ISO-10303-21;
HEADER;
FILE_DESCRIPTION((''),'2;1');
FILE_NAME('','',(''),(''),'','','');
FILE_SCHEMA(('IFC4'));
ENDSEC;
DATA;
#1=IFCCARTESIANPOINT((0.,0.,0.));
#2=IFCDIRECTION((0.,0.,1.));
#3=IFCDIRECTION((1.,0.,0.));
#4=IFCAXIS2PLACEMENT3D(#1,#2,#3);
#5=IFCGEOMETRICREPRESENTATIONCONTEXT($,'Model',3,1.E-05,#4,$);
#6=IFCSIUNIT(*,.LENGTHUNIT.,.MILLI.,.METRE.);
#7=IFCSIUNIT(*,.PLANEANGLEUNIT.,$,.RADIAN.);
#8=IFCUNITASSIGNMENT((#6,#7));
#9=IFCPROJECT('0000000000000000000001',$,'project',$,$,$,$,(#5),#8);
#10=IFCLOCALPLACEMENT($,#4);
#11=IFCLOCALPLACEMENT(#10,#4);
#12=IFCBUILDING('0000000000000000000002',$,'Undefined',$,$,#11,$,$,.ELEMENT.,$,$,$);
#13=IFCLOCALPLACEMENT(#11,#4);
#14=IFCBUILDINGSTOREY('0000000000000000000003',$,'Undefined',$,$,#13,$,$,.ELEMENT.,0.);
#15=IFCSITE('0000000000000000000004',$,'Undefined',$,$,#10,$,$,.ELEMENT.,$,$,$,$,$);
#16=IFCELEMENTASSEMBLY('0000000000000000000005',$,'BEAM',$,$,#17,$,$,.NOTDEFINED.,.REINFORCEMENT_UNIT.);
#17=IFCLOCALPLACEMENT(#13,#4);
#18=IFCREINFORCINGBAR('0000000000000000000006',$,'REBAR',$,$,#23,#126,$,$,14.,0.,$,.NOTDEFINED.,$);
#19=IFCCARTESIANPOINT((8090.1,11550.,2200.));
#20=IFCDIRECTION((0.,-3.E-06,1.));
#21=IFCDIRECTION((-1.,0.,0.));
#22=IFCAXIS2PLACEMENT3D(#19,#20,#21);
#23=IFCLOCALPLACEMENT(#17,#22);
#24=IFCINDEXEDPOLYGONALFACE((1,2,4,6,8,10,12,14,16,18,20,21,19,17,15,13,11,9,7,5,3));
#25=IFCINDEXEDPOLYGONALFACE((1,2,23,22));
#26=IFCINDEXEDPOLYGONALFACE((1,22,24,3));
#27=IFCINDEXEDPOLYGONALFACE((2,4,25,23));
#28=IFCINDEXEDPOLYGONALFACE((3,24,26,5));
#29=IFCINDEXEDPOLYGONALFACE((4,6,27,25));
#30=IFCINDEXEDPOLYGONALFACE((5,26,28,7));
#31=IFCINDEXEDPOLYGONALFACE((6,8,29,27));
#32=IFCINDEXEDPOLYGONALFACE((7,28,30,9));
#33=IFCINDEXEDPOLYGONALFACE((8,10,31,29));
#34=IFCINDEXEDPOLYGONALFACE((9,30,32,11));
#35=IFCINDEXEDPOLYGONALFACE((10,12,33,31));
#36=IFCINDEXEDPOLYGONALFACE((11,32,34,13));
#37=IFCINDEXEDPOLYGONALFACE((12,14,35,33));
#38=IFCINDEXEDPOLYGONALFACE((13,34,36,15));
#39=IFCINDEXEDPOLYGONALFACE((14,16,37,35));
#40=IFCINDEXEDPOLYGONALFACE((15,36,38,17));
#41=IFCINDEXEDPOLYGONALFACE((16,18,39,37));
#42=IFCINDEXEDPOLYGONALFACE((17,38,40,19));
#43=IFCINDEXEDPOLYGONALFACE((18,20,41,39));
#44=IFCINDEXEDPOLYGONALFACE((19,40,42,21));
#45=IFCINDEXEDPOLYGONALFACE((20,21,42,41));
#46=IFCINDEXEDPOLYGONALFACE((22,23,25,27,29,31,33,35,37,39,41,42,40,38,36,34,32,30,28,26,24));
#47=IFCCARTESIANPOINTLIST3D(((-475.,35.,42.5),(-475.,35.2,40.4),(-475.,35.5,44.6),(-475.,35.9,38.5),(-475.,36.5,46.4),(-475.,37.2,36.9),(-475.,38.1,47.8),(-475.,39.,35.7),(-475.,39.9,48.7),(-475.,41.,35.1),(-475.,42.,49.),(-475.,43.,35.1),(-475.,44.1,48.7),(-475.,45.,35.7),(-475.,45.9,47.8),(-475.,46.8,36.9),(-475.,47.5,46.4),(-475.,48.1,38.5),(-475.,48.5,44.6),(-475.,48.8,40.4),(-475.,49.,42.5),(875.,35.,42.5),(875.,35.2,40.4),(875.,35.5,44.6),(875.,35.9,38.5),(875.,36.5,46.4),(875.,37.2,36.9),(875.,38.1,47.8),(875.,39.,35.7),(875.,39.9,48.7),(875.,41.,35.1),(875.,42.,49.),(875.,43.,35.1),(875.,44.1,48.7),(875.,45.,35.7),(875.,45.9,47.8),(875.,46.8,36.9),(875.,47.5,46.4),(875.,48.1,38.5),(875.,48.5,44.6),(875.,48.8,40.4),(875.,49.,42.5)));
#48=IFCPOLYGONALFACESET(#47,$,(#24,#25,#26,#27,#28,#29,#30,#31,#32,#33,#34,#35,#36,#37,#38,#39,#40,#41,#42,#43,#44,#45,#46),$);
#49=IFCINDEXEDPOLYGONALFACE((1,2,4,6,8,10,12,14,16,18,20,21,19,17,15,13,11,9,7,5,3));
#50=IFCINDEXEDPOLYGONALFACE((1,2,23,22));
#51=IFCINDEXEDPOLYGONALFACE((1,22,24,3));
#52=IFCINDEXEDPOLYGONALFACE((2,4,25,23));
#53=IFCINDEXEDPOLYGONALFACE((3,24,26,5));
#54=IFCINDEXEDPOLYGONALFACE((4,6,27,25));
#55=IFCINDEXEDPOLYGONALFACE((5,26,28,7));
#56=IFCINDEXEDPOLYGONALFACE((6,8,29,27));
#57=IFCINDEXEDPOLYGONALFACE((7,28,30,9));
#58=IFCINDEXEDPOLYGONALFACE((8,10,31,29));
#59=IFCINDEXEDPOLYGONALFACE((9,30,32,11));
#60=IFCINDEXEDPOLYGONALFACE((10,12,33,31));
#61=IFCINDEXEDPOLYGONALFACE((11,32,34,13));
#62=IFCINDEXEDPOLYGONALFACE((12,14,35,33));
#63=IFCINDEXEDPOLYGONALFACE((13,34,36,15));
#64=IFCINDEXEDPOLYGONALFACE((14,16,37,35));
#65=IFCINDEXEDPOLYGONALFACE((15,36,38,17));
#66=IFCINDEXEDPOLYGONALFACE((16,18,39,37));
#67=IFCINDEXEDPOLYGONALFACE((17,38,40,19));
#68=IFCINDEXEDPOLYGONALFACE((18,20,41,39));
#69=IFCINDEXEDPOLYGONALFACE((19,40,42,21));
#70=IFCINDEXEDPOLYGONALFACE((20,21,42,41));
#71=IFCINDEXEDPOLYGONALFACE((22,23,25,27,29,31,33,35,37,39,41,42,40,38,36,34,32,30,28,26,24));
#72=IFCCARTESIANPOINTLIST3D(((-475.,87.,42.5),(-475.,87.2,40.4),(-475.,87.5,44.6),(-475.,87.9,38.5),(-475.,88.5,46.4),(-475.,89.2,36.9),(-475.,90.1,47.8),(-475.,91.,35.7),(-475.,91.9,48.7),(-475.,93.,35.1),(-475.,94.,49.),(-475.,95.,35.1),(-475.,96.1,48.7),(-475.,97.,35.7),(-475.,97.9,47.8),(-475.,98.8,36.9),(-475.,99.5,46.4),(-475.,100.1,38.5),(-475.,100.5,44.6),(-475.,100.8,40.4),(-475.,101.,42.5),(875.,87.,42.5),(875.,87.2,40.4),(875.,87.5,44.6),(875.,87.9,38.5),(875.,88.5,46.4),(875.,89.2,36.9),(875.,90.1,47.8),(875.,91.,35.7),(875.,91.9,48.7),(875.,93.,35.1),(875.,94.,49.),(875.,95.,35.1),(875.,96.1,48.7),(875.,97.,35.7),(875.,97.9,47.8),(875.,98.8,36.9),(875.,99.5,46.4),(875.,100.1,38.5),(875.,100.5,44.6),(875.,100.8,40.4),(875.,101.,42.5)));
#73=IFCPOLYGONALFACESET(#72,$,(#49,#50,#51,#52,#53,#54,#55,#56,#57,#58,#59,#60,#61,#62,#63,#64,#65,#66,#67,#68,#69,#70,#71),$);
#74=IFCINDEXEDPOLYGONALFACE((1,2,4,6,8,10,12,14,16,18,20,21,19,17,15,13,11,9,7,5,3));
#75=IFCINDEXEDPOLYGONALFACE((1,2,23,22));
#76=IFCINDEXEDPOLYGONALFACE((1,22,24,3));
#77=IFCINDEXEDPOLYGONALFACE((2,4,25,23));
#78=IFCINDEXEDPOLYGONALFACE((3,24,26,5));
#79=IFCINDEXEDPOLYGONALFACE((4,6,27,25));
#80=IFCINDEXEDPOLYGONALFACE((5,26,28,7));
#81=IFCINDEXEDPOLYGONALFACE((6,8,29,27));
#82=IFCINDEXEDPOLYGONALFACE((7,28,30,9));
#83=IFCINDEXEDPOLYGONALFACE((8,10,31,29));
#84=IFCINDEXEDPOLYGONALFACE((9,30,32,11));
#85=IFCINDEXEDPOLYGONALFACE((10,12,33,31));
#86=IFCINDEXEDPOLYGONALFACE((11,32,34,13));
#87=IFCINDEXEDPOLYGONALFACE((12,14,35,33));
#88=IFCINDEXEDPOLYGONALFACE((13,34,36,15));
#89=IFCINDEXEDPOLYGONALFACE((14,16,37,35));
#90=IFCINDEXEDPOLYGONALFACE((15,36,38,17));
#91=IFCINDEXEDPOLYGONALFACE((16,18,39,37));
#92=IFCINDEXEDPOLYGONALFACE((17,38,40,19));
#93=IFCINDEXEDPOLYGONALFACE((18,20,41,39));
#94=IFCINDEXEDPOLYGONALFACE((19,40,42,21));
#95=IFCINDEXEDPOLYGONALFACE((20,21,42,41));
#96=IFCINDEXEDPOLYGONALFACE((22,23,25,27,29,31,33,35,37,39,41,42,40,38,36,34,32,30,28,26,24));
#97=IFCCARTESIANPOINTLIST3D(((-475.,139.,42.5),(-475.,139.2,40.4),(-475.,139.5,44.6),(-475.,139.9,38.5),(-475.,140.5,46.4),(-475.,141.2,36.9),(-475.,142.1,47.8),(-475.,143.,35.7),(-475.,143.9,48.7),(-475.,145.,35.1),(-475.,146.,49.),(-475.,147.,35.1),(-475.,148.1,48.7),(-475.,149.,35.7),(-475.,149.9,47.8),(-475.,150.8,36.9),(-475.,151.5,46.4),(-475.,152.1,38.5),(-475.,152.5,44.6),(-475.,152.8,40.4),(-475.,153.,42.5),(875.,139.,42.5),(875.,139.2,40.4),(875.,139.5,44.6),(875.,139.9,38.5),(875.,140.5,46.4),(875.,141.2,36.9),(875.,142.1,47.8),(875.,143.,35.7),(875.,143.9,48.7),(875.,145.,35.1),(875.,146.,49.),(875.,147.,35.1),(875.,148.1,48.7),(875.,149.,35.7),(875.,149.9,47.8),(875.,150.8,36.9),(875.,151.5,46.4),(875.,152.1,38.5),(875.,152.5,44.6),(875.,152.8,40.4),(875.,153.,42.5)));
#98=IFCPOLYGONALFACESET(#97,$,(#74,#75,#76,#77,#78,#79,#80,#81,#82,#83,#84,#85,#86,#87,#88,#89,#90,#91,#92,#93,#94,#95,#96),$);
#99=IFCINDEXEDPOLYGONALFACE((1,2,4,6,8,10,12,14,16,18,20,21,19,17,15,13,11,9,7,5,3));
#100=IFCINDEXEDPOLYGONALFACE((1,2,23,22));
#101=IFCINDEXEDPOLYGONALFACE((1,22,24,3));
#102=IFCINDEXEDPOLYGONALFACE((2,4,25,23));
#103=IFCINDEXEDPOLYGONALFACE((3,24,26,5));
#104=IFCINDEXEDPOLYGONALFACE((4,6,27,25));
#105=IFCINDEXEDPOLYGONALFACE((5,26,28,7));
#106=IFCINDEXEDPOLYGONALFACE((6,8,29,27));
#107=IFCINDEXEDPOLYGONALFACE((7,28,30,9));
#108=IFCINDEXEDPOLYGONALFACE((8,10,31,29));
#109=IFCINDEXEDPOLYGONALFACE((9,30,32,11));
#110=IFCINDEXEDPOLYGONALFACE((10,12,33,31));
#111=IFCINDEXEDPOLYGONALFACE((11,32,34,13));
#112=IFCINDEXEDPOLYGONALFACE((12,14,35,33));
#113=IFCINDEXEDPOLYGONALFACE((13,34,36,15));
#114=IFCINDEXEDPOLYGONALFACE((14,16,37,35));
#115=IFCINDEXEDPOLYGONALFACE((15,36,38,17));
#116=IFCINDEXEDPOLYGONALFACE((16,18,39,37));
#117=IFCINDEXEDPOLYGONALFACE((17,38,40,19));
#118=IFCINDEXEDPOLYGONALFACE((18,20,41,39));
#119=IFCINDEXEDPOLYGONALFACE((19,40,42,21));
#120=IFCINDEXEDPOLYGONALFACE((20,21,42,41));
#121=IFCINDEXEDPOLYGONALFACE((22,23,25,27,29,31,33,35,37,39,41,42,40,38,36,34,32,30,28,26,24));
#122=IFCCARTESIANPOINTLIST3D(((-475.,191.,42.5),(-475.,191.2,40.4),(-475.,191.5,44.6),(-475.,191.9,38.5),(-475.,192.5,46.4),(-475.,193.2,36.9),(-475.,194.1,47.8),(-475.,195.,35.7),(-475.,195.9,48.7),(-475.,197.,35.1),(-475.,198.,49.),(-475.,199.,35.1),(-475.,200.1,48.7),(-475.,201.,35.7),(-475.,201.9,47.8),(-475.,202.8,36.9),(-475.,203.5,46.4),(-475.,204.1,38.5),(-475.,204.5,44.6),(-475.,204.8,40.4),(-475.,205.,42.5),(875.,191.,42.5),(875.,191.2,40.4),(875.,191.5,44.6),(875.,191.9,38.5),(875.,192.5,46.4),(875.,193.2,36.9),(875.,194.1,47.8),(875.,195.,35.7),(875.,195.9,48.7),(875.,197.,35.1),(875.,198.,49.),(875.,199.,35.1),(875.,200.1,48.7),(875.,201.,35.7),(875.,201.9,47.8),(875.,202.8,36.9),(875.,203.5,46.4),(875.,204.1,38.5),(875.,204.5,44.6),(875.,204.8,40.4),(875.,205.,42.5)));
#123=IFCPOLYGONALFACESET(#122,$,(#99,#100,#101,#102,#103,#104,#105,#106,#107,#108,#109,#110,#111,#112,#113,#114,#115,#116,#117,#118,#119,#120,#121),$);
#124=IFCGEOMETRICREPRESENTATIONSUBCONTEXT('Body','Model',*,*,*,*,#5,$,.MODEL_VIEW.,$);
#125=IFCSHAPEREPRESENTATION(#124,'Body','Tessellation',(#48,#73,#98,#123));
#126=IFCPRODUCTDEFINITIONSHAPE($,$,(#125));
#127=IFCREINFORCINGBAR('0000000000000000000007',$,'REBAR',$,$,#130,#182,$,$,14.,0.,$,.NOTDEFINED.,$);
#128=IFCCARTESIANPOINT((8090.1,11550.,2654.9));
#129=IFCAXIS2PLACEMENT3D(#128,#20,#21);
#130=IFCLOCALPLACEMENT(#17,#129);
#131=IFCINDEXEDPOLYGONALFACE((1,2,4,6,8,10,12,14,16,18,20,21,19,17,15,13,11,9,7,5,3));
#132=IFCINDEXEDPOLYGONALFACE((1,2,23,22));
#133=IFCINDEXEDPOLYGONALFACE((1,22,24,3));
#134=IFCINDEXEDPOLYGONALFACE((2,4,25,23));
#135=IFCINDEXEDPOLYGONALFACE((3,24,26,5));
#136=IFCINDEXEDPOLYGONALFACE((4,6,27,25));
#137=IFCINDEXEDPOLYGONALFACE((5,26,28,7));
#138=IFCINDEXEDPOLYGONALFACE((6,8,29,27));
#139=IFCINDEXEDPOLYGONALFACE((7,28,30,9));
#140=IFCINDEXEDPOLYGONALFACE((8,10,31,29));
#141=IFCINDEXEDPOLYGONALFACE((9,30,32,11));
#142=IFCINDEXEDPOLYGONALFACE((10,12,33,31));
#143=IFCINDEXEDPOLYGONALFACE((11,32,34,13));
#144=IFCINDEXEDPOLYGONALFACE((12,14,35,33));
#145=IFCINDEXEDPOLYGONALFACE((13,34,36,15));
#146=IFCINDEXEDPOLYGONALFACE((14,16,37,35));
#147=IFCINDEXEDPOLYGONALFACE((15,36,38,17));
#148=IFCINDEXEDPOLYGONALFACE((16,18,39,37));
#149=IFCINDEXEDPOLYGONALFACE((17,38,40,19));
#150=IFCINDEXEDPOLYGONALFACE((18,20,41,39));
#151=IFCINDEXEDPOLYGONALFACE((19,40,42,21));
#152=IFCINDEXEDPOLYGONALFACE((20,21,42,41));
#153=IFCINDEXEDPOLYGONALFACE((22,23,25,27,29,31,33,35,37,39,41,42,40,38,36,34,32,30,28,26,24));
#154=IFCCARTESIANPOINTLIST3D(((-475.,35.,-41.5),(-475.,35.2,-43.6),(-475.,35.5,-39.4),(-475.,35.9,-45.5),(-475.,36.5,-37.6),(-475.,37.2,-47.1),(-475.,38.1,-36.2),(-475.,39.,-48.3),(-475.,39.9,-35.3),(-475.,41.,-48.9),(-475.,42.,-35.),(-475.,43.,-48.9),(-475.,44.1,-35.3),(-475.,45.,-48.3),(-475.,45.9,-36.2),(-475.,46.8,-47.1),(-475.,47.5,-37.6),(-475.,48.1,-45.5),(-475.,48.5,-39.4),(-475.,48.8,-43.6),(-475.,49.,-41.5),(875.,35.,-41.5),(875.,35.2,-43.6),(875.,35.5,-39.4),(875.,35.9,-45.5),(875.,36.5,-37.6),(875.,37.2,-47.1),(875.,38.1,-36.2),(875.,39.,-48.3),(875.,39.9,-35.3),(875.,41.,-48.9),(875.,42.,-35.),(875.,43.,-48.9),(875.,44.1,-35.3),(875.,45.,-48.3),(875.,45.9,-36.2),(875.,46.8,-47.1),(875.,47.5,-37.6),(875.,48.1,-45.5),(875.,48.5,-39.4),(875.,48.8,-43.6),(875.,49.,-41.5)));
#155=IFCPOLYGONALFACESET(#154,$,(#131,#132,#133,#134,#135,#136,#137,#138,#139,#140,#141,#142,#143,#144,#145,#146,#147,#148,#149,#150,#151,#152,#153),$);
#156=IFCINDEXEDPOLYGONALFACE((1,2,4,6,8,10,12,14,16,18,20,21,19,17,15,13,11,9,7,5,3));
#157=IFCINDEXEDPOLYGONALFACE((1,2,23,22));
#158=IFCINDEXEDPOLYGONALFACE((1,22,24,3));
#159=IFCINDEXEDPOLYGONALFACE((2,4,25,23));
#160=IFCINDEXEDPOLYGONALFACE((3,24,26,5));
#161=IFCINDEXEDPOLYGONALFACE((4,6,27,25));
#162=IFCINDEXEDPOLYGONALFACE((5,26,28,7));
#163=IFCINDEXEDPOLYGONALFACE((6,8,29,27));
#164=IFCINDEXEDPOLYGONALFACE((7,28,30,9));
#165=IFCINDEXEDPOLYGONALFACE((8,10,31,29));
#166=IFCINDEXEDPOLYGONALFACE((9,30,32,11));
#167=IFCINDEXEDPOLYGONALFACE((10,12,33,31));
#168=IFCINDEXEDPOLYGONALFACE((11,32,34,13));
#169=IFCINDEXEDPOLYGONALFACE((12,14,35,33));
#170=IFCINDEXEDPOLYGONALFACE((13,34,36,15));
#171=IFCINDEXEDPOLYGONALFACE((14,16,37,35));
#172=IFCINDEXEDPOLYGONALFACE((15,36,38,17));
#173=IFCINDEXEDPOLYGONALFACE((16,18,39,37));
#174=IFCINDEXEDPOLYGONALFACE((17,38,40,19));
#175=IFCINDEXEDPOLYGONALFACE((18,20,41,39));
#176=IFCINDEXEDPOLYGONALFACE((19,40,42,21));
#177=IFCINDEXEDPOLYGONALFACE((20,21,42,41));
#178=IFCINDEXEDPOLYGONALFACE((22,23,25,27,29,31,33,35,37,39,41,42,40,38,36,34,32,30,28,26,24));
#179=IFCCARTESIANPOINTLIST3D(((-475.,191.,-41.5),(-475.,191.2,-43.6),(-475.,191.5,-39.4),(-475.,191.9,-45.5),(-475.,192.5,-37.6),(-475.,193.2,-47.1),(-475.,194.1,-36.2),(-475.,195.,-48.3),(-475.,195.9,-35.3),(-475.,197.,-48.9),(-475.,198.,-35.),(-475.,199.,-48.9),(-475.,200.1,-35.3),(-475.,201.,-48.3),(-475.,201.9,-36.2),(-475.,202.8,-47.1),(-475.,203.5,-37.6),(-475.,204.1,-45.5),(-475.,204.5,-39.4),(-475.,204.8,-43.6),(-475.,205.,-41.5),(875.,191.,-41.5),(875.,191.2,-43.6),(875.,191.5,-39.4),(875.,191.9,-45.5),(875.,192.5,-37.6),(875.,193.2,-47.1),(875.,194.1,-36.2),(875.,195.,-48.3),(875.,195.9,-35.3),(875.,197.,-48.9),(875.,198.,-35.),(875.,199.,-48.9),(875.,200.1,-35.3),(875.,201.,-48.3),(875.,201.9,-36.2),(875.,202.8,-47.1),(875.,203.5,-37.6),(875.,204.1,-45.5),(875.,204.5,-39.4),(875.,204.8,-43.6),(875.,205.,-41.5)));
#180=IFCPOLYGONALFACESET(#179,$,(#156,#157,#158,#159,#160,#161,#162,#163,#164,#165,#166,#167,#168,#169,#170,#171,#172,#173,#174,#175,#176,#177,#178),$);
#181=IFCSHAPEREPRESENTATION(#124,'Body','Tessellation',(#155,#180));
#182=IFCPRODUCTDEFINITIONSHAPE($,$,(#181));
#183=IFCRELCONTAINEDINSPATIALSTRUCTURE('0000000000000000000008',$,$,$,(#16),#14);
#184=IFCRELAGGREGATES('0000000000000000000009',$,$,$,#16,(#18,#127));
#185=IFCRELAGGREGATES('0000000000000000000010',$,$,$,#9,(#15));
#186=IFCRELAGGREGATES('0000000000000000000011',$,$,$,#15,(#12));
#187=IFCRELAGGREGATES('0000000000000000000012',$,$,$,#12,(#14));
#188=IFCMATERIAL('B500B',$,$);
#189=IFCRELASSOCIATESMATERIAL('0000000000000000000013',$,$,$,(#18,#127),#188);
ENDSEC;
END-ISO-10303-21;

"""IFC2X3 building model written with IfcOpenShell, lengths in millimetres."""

from ifc_helpers import new_model, entity, si_unit, frame, origin_with_axes, place, context, subcontext, project, spatial, source, transform, mapped, material, element, aggregate, save


model = new_model("IFC2X3")

# Units and contexts
model_context = context("Model", 3, precision=1e-05, world=origin_with_axes())
body_context = subcontext(model_context, "Body", "Model", "MODEL_VIEW")
ifc_project = project(units=[si_unit("LENGTHUNIT", "METRE", prefix="MILLI"), si_unit("PLANEANGLEUNIT", "RADIAN")], contexts=[model_context])

# Site, building, storey
site_placement = place(None, origin_with_axes())
site = spatial("IfcSite", under=ifc_project, at=site_placement, Name="Undefined", CompositionType="ELEMENT")
building_placement = place(site_placement, origin_with_axes())
building = spatial("IfcBuilding", under=site, at=building_placement, Name="Undefined", CompositionType="ELEMENT")
storey_placement = place(building_placement, origin_with_axes())
storey = spatial("IfcBuildingStorey", under=building, at=storey_placement, Name="Undefined", CompositionType="ELEMENT", Elevation=0.0)

# Element assembly
assembly_1_placement = place(storey_placement, origin_with_axes())
assembly_1 = element("IfcElementAssembly", 1, at=assembly_1_placement, inside=storey, Name="BEAM", AssemblyPlace="NOTDEFINED", PredefinedType="REINFORCEMENT_UNIT")

# Shared definitions
ifc_material_1 = material(Name="B500B")

# Reinforcing bars
shared_shape_1 = source(origin_with_axes(), body_context, "Body", "AdvancedSweptSolid", [
    entity("IfcSweptDiskSolid", entity("IfcTrimmedCurve", entity("IfcLine", entity("IfcCartesianPoint", [0.0, 0.0, 0.0]), entity("IfcVector", entity("IfcDirection", [1.0, 0.0, 0.0]), 1.0)), [entity("IfcParameterValue", 0.0)], [entity("IfcParameterValue", 1349.999613)], True, "PARAMETER"), 7.0, None, 0.0, 1350.0),
])
shared_shape_2 = source(origin_with_axes(), body_context, "Body", "AdvancedSweptSolid", [
    entity("IfcSweptDiskSolid", entity("IfcTrimmedCurve", entity("IfcLine", entity("IfcCartesianPoint", [0.0, 0.0, 0.0]), entity("IfcVector", entity("IfcDirection", [1.0, 0.0, 0.0]), 1.0)), [entity("IfcParameterValue", 0.0)], [entity("IfcParameterValue", 1349.999613)], True, "PARAMETER"), 7.0, None, 0.0, 1350.0),
])
shared_shape_3 = source(origin_with_axes(), body_context, "Body", "AdvancedSweptSolid", [
    entity("IfcSweptDiskSolid", entity("IfcTrimmedCurve", entity("IfcLine", entity("IfcCartesianPoint", [0.0, 0.0, 0.0]), entity("IfcVector", entity("IfcDirection", [1.0, 0.0, 0.0]), 1.0)), [entity("IfcParameterValue", 0.0)], [entity("IfcParameterValue", 1349.999613)], True, "PARAMETER"), 7.0, None, 0.0, 1350.0),
])
shared_shape_4 = source(origin_with_axes(), body_context, "Body", "AdvancedSweptSolid", [
    entity("IfcSweptDiskSolid", entity("IfcTrimmedCurve", entity("IfcLine", entity("IfcCartesianPoint", [0.0, 0.0, 0.0]), entity("IfcVector", entity("IfcDirection", [1.0, 0.0, 0.0]), 1.0)), [entity("IfcParameterValue", 0.0)], [entity("IfcParameterValue", 1349.999613)], True, "PARAMETER"), 7.0, None, 0.0, 1350.0),
])
reinforcing_bar_1_placement = place(assembly_1_placement, frame((8090.1, 11550.0, 2200.0), z_axis=(0.0, -0.000003, 1.0), x_axis=(-1.0, 0.0, 0.0)))
reinforcing_bar_1 = element("IfcReinforcingBar", 2, at=reinforcing_bar_1_placement, material=ifc_material_1, Name="REBAR", BarRole="NOTDEFINED", CrossSectionArea=0.0, NominalDiameter=14.0, context=body_context, shape_type="MappedRepresentation", body=[
    mapped(shared_shape_1, transform((-475.0, 42.0, 42.0))),
    mapped(shared_shape_2, transform((-475.0, 94.0, 42.0))),
    mapped(shared_shape_3, transform((-475.0, 146.0, 42.0))),
    mapped(shared_shape_4, transform((-475.0, 198.0, 42.0))),
])
shared_shape_5 = source(origin_with_axes(), body_context, "Body", "AdvancedSweptSolid", [
    entity("IfcSweptDiskSolid", entity("IfcTrimmedCurve", entity("IfcLine", entity("IfcCartesianPoint", [0.0, 0.0, 0.0]), entity("IfcVector", entity("IfcDirection", [1.0, 0.0, 0.0]), 1.0)), [entity("IfcParameterValue", 0.0)], [entity("IfcParameterValue", 1349.999613)], True, "PARAMETER"), 7.0, None, 0.0, 1350.0),
])
shared_shape_6 = source(origin_with_axes(), body_context, "Body", "AdvancedSweptSolid", [
    entity("IfcSweptDiskSolid", entity("IfcTrimmedCurve", entity("IfcLine", entity("IfcCartesianPoint", [0.0, 0.0, 0.0]), entity("IfcVector", entity("IfcDirection", [1.0, 0.0, 0.0]), 1.0)), [entity("IfcParameterValue", 0.0)], [entity("IfcParameterValue", 1349.999613)], True, "PARAMETER"), 7.0, None, 0.0, 1350.0),
])
reinforcing_bar_2_placement = place(assembly_1_placement, frame((8090.1, 11550.0, 2654.9), z_axis=(0.0, -0.000003, 1.0), x_axis=(-1.0, 0.0, 0.0)))
reinforcing_bar_2 = element("IfcReinforcingBar", 3, at=reinforcing_bar_2_placement, material=ifc_material_1, Name="REBAR", BarRole="NOTDEFINED", CrossSectionArea=0.0, NominalDiameter=14.0, context=body_context, shape_type="MappedRepresentation", body=[
    mapped(shared_shape_5, transform((-475.0, 42.0, -42.0))),
    mapped(shared_shape_6, transform((-475.0, 198.0, -42.0))),
])
aggregate(assembly_1, [reinforcing_bar_1, reinforcing_bar_2])

save(model, "model.ifc")
